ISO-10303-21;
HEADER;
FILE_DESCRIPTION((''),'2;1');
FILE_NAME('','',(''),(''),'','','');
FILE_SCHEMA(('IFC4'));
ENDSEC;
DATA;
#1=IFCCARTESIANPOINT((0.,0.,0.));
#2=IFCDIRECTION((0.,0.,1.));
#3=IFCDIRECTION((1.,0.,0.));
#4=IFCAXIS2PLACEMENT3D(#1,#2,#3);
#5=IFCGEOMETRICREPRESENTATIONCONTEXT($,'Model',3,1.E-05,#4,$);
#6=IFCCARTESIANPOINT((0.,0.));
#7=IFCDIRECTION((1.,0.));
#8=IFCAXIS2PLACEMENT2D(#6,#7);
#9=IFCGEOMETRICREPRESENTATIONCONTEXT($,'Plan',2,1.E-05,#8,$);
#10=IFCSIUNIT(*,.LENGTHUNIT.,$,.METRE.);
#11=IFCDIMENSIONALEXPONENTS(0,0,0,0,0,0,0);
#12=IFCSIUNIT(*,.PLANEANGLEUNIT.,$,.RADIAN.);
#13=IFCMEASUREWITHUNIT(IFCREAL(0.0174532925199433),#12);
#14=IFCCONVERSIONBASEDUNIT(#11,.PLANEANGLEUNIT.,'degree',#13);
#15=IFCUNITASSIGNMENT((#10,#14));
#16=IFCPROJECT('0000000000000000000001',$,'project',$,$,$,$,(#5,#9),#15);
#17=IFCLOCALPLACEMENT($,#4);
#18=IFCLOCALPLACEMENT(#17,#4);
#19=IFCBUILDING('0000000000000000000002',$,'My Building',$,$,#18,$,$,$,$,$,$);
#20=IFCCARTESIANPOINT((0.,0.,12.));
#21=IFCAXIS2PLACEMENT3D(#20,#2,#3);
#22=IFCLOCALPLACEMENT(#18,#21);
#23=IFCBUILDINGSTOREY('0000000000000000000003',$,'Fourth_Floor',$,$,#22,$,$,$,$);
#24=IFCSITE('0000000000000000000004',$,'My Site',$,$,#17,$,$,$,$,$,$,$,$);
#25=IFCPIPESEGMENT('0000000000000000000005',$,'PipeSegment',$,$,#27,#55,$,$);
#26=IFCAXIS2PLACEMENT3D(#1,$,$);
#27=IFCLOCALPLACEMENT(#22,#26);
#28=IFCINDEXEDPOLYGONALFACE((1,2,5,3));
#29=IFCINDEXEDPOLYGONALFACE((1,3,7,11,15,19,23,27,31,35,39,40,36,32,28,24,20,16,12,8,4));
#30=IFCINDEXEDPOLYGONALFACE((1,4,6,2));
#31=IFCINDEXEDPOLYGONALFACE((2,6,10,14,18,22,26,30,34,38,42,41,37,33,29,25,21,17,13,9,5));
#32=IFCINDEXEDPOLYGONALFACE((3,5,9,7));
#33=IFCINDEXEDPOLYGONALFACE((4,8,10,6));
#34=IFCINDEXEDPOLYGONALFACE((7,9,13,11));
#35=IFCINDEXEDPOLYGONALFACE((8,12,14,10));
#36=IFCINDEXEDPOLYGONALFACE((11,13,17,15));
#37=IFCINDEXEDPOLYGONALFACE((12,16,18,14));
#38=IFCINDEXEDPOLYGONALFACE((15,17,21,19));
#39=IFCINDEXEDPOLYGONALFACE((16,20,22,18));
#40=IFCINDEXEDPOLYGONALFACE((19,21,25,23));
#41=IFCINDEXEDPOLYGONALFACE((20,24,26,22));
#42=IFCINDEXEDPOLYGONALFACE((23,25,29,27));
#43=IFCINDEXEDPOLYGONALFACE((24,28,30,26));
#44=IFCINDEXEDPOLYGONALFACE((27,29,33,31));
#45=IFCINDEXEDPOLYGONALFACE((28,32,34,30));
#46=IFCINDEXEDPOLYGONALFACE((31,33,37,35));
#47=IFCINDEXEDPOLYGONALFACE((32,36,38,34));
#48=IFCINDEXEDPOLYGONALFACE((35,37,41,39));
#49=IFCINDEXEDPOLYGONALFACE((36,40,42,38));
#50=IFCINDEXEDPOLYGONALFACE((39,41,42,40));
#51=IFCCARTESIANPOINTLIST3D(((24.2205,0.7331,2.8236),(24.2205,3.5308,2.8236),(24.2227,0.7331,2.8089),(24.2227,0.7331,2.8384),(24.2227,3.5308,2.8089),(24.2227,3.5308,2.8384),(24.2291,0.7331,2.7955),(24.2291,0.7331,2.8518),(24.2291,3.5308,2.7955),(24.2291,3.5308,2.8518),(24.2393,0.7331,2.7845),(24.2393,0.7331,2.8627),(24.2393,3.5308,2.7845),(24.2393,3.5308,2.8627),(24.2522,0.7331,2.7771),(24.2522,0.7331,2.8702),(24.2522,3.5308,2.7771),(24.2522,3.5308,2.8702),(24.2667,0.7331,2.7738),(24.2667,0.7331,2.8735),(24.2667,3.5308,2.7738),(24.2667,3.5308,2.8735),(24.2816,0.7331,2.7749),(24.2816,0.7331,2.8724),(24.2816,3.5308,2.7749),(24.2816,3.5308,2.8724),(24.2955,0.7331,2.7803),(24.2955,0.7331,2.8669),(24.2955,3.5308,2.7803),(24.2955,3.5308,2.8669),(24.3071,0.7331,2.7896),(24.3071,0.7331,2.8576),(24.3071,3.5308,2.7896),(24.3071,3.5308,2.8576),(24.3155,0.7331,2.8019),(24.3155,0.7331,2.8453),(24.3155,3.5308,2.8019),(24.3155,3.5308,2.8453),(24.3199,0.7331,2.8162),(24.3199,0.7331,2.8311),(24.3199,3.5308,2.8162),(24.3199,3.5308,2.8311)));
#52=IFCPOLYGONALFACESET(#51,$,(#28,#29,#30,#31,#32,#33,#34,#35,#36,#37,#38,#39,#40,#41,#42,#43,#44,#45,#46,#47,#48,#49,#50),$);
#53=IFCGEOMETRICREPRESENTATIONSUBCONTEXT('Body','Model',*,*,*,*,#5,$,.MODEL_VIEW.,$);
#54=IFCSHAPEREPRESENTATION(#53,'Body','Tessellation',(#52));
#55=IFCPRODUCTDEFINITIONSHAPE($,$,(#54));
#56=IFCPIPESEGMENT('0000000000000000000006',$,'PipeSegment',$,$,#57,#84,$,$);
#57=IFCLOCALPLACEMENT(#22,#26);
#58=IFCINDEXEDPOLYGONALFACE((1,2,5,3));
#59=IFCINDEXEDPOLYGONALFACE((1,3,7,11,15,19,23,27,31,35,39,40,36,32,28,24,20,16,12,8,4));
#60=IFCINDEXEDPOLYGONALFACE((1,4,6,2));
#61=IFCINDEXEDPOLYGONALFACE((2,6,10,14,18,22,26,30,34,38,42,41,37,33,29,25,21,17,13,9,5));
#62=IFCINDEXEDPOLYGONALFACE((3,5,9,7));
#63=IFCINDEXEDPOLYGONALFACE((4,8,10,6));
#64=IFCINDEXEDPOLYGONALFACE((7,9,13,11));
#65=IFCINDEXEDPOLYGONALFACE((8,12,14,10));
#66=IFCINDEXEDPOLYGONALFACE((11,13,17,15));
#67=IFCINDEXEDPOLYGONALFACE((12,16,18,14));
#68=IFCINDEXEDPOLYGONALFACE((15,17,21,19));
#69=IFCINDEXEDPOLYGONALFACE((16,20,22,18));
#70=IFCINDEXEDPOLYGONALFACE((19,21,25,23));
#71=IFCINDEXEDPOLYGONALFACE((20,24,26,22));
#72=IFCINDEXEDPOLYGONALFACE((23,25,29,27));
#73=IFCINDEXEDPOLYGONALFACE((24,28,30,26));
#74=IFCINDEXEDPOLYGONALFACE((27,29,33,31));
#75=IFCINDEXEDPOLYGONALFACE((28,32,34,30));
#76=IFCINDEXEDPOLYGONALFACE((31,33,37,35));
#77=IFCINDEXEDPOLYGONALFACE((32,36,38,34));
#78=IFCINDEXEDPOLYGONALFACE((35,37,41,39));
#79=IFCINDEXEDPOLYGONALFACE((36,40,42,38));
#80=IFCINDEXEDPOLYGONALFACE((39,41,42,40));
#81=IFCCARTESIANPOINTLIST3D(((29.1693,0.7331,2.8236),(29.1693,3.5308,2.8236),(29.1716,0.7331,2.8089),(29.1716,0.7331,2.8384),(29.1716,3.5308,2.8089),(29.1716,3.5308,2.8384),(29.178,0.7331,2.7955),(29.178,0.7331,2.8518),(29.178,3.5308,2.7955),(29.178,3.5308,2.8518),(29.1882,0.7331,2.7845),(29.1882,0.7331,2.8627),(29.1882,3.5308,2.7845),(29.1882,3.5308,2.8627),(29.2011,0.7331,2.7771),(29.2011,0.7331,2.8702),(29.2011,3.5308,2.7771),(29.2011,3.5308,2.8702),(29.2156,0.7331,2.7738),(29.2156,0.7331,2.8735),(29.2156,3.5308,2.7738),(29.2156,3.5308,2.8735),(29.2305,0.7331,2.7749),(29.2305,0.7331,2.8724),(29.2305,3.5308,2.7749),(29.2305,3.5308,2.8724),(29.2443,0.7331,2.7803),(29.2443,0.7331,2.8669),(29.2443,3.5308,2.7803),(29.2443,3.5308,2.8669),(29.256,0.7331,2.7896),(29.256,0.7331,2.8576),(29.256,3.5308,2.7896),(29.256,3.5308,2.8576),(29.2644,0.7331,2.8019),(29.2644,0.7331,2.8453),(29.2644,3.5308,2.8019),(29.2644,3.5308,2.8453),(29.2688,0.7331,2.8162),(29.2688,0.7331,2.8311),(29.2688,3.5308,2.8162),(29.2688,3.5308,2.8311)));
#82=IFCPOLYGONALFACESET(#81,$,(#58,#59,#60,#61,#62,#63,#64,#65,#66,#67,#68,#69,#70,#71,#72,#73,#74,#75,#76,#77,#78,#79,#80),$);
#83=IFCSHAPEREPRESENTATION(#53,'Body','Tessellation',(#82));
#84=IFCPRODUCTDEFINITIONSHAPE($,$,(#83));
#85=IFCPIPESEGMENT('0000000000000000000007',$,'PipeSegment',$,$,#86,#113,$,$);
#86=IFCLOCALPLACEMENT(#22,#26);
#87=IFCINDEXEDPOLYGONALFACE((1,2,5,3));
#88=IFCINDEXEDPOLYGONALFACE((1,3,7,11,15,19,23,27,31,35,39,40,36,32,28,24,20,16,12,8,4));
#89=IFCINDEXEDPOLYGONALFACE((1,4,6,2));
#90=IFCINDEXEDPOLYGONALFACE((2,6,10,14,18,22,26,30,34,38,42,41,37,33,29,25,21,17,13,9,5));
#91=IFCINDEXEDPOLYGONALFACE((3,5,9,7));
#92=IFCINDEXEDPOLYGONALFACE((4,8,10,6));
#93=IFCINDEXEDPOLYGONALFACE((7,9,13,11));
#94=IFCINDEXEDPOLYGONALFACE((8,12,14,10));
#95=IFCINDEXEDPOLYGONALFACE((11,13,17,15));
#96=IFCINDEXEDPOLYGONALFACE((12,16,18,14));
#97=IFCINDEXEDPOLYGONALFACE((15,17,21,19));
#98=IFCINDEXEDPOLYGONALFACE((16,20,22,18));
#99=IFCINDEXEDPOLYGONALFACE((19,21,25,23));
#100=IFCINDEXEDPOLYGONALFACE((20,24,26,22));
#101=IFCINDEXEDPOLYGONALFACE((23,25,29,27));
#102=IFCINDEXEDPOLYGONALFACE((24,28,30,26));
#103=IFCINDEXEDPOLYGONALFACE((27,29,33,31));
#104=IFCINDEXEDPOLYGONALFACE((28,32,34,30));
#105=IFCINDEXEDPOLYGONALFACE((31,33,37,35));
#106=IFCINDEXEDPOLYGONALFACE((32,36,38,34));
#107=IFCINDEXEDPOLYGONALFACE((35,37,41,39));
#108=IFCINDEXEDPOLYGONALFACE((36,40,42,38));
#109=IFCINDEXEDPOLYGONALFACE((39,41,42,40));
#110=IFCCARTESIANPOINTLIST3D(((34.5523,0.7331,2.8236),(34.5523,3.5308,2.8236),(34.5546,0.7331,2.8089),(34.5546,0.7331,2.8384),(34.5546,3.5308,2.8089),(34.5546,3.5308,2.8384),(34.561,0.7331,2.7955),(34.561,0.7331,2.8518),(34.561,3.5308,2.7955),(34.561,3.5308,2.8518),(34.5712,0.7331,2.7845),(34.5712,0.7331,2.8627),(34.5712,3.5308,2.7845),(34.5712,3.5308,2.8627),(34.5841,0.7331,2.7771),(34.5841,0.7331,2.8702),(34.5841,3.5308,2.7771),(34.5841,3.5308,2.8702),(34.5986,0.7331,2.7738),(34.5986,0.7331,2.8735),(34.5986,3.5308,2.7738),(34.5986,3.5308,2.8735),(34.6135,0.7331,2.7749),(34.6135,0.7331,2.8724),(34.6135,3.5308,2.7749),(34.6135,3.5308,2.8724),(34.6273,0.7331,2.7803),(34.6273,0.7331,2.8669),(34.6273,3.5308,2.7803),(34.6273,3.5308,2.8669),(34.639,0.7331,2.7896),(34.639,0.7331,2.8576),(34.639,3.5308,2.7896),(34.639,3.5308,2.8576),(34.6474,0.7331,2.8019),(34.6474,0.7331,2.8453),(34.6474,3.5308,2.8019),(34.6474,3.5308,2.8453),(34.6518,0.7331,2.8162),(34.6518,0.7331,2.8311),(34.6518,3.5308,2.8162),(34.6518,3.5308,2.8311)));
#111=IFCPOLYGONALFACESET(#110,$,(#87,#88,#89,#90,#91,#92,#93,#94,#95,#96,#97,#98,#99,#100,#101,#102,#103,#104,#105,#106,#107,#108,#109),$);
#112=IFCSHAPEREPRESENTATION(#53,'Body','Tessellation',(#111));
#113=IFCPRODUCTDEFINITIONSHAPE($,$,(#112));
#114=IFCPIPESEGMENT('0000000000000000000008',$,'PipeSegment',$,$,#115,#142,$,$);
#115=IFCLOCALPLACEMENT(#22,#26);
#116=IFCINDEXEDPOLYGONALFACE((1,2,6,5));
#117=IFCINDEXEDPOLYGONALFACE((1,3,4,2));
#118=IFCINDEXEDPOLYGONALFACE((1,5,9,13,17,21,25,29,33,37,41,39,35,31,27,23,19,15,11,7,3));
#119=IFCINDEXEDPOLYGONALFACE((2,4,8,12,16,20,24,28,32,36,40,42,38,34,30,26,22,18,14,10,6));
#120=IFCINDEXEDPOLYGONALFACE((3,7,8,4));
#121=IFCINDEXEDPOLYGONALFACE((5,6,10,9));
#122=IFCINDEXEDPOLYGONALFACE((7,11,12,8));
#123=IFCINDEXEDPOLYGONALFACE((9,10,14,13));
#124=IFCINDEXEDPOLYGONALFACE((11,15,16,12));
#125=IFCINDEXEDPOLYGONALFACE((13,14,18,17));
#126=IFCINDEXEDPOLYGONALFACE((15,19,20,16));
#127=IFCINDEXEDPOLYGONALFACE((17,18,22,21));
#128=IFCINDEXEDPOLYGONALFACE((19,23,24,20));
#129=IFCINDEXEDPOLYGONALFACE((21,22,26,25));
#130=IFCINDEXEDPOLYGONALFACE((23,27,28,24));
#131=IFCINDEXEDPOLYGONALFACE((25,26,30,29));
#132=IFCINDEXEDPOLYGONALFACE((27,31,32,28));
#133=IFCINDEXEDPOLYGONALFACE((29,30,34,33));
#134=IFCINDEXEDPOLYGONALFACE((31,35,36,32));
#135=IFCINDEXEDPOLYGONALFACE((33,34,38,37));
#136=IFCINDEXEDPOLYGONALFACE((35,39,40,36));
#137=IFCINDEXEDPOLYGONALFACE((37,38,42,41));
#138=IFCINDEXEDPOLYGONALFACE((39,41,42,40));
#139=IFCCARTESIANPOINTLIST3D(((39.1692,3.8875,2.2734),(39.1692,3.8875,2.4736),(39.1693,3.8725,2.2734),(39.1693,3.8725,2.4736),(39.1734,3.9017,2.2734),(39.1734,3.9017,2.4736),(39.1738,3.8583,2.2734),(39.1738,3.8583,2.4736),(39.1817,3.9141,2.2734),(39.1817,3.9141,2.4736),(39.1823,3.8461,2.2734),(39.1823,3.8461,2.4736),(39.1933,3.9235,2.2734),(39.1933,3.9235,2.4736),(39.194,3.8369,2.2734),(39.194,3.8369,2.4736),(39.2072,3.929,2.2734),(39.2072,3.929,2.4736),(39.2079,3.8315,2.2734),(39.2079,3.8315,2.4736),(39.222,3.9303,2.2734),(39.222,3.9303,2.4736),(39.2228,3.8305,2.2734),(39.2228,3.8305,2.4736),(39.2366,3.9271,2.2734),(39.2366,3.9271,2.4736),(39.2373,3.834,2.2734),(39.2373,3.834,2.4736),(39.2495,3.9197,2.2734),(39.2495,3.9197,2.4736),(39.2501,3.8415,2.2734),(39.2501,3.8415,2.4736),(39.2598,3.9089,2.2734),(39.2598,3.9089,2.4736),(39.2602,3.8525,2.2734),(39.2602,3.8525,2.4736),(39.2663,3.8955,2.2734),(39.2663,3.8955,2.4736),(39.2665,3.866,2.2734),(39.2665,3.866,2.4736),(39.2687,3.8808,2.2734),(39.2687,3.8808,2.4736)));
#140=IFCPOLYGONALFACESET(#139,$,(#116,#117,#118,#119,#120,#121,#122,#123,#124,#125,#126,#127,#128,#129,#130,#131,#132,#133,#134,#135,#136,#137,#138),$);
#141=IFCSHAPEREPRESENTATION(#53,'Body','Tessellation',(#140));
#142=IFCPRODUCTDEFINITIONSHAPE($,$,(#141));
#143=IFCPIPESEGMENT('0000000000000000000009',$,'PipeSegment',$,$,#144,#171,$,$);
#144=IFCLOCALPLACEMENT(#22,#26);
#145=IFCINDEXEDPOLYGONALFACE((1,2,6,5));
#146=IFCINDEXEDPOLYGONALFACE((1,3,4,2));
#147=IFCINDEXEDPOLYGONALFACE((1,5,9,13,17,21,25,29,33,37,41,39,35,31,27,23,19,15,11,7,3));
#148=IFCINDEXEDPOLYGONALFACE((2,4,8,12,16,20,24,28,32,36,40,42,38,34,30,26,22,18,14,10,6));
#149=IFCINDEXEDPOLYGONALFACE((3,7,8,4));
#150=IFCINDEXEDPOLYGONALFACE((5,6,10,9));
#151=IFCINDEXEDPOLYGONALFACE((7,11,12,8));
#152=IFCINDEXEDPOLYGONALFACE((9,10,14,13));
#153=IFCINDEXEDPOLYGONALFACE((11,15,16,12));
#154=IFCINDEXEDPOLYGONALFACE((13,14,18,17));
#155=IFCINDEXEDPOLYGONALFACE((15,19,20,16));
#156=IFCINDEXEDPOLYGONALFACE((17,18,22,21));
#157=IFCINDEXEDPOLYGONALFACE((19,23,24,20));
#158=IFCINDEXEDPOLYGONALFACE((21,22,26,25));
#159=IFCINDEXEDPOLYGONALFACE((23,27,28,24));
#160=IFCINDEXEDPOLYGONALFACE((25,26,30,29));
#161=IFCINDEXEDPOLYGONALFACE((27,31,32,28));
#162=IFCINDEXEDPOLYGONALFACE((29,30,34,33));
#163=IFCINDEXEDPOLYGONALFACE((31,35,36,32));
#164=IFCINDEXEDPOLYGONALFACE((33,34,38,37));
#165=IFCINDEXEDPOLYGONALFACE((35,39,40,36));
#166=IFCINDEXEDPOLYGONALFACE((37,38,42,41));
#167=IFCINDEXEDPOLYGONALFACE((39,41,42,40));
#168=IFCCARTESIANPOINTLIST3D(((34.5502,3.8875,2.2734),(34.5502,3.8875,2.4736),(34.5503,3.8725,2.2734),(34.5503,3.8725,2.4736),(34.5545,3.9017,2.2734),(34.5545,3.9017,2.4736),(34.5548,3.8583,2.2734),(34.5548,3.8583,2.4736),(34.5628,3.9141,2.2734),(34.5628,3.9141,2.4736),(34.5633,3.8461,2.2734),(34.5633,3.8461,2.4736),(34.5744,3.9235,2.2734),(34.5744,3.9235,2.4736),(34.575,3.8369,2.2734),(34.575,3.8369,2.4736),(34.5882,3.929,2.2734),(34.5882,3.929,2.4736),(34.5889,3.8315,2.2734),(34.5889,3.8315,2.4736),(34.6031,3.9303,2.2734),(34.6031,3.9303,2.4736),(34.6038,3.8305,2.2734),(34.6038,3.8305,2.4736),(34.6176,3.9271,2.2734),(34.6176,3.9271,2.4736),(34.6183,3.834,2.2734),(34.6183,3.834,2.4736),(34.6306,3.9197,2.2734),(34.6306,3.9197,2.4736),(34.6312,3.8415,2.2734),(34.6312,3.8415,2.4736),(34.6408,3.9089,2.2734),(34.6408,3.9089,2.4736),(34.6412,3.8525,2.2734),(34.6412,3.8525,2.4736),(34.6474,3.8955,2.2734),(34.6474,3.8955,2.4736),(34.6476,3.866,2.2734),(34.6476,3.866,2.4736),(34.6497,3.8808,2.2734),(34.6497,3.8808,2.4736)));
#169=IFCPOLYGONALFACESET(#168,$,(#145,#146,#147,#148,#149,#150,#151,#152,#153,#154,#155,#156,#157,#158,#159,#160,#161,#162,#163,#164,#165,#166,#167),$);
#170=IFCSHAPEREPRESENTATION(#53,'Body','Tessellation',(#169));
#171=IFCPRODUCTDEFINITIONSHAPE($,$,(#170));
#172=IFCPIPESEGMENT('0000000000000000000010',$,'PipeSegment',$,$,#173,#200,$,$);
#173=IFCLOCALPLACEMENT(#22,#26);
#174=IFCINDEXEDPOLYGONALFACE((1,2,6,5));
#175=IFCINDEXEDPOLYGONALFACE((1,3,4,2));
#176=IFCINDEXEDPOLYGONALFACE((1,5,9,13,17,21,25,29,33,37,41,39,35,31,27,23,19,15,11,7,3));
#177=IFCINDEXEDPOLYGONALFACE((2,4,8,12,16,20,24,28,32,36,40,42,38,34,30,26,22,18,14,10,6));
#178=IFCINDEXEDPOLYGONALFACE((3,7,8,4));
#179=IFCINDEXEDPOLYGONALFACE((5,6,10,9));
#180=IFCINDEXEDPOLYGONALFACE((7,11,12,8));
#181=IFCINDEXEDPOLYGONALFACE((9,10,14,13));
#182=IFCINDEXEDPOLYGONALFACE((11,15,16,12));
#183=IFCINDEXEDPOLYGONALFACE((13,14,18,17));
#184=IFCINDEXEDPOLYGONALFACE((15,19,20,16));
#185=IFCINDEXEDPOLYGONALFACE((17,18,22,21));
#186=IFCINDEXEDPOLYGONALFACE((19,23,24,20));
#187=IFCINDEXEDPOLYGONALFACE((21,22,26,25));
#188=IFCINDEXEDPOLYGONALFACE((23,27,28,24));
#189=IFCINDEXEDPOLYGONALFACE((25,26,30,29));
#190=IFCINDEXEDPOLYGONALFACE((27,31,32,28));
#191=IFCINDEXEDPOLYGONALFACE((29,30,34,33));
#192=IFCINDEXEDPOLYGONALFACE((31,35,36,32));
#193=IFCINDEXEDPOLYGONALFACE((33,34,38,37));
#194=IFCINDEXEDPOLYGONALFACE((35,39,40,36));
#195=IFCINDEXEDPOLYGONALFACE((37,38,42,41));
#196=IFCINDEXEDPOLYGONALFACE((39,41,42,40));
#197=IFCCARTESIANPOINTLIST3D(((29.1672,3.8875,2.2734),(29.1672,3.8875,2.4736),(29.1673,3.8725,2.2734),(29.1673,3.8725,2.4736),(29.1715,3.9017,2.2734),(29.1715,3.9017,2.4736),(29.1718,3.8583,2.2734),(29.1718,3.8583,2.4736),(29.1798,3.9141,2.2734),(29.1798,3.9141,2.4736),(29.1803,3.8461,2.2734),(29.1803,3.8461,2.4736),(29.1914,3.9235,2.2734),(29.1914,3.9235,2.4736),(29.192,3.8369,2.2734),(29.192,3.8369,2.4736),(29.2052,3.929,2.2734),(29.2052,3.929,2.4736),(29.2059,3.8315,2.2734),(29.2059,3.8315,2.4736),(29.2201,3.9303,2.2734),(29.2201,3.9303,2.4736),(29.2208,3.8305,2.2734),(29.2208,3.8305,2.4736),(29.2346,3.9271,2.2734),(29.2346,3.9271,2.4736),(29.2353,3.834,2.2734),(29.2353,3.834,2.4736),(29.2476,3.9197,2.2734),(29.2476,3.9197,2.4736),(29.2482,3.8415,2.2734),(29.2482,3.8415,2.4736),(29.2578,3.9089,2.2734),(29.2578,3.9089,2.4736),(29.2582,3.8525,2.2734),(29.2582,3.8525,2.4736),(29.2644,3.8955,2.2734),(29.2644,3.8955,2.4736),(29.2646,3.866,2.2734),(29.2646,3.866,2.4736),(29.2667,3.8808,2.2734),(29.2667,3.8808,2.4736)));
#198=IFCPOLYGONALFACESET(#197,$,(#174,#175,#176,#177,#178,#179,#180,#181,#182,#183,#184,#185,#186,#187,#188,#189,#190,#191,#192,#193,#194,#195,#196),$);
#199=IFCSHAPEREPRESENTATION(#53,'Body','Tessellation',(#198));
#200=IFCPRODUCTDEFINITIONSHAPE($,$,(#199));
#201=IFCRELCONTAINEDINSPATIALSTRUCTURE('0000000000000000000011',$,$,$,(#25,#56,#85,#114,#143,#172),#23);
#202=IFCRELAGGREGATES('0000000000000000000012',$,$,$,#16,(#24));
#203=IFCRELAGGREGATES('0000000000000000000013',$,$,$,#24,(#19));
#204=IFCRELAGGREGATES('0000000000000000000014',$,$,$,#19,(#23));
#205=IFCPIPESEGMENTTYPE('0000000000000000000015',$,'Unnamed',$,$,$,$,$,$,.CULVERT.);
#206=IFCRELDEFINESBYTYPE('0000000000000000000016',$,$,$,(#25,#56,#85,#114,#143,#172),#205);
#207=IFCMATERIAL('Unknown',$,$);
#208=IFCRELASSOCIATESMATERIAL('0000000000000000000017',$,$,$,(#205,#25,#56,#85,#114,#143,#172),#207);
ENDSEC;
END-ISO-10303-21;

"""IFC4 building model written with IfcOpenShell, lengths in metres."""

from ifc_helpers import new_model, entity, si_unit, converted_unit, frame, origin_with_axes, origin_2d_with_axis, place, context, subcontext, project, spatial, circle, extrude, material, material_profile, profile_set, profile_usage, type_object, element, save


model = new_model("IFC4")

# Units and contexts
model_context = context("Model", 3, precision=1e-05, world=origin_with_axes())
plan_context = context("Plan", 2, precision=1e-05, world=origin_2d_with_axis())
body_context_1 = subcontext(model_context, "Body", "Model", "MODEL_VIEW")
ifc_project = project(units=[si_unit("LENGTHUNIT", "METRE"), converted_unit("PLANEANGLEUNIT", "degree", entity("IfcReal", 0.0174532925199433), si_unit("PLANEANGLEUNIT", "RADIAN"), dimensions=[0, 0, 0, 0, 0, 0, 0])], contexts=[model_context, plan_context])

# Site, building, storey
site_placement = place(None, origin_with_axes())
site = spatial("IfcSite", under=ifc_project, at=site_placement, Name="My Site")
building_placement = place(site_placement, origin_with_axes())
building = spatial("IfcBuilding", under=site, at=building_placement, Name="My Building")
storey_placement = place(building_placement, frame((0.0, 0.0, 12.0), z_axis=(0.0, 0.0, 1.0), x_axis=(1.0, 0.0, 0.0)))
storey = spatial("IfcBuildingStorey", under=building, at=storey_placement, Name="Fourth_Floor")

# Shared definitions
ifc_material = material(Name="Unknown")

# Pipe segments
ifc_material_profile_1 = material_profile(ifc_material, circle(Radius=0.05))
ifc_profile_set_1 = profile_set([ifc_material_profile_1])
ifc_profile_usage_1 = profile_usage(ifc_profile_set_1, cardinal=5)
pipe_segment_type = type_object("IfcPipeSegmentType", Name="Unnamed", PredefinedType="CULVERT", material=ifc_profile_set_1)
pipe_segment_1_placement = place(storey_placement, frame((24.2705, 0.7331, 2.8236), z_axis=(0.0, 1.0, 0.0), x_axis=(-1.0, 0.0, 0.0)))
element("IfcPipeSegment", 1, at=pipe_segment_1_placement, inside=storey, type_object=pipe_segment_type, material=ifc_profile_usage_1, Name="PipeSegment", context=body_context_1, shape_type="SweptSolid", body=[
    extrude(circle(Radius=0.05), origin_with_axes(), (0.0, 0.0, 1.0), 2.7976),
])
ifc_profile_usage_2 = profile_usage(ifc_profile_set_1, cardinal=5)
pipe_segment_2_placement = place(storey_placement, frame((29.2193, 0.7331, 2.8236), z_axis=(0.0, 1.0, 0.0), x_axis=(-1.0, 0.0, 0.0)))
element("IfcPipeSegment", 2, at=pipe_segment_2_placement, inside=storey, type_object=pipe_segment_type, material=ifc_profile_usage_2, Name="PipeSegment", context=body_context_1, shape_type="SweptSolid", body=[
    extrude(circle(Radius=0.05), origin_with_axes(), (0.0, 0.0, 1.0), 2.7976),
])
ifc_profile_usage_3 = profile_usage(ifc_profile_set_1, cardinal=5)
pipe_segment_3_placement = place(storey_placement, frame((34.6023, 0.7331, 2.8236), z_axis=(0.0, 1.0, 0.0), x_axis=(-1.0, 0.0, 0.0)))
element("IfcPipeSegment", 3, at=pipe_segment_3_placement, inside=storey, type_object=pipe_segment_type, material=ifc_profile_usage_3, Name="PipeSegment", context=body_context_1, shape_type="SweptSolid", body=[
    extrude(circle(Radius=0.05), origin_with_axes(), (0.0, 0.0, 1.0), 2.7976),
])
ifc_profile_usage_4 = profile_usage(ifc_profile_set_1, cardinal=5)
pipe_segment_4_placement = place(storey_placement, frame((39.2187, 3.8804, 2.4736), z_axis=(0.000001, 0.0, -1.0), x_axis=(0.999971, 0.007564, 0.000001)))
element("IfcPipeSegment", 4, at=pipe_segment_4_placement, inside=storey, type_object=pipe_segment_type, material=ifc_profile_usage_4, Name="PipeSegment", context=body_context_1, shape_type="SweptSolid", body=[
    extrude(circle(Radius=0.05), origin_with_axes(), (0.0, 0.0, 1.0), 0.2002),
])
ifc_profile_usage_5 = profile_usage(ifc_profile_set_1, cardinal=5)
pipe_segment_5_placement = place(storey_placement, frame((34.5997, 3.8804, 2.4736), z_axis=(0.000001, 0.0, -1.0), x_axis=(0.999971, 0.007564, 0.000001)))
element("IfcPipeSegment", 5, at=pipe_segment_5_placement, inside=storey, type_object=pipe_segment_type, material=ifc_profile_usage_5, Name="PipeSegment", context=body_context_1, shape_type="SweptSolid", body=[
    extrude(circle(Radius=0.05), origin_with_axes(), (0.0, 0.0, 1.0), 0.2002),
])
ifc_profile_usage_6 = profile_usage(ifc_profile_set_1, cardinal=5)
pipe_segment_6_placement = place(storey_placement, frame((29.2167, 3.8804, 2.4736), z_axis=(0.000001, 0.0, -1.0), x_axis=(0.999971, 0.007564, 0.000001)))
element("IfcPipeSegment", 6, at=pipe_segment_6_placement, inside=storey, type_object=pipe_segment_type, material=ifc_profile_usage_6, Name="PipeSegment", context=body_context_1, shape_type="SweptSolid", body=[
    extrude(circle(Radius=0.05), origin_with_axes(), (0.0, 0.0, 1.0), 0.2002),
])

save(model, "model.ifc")
